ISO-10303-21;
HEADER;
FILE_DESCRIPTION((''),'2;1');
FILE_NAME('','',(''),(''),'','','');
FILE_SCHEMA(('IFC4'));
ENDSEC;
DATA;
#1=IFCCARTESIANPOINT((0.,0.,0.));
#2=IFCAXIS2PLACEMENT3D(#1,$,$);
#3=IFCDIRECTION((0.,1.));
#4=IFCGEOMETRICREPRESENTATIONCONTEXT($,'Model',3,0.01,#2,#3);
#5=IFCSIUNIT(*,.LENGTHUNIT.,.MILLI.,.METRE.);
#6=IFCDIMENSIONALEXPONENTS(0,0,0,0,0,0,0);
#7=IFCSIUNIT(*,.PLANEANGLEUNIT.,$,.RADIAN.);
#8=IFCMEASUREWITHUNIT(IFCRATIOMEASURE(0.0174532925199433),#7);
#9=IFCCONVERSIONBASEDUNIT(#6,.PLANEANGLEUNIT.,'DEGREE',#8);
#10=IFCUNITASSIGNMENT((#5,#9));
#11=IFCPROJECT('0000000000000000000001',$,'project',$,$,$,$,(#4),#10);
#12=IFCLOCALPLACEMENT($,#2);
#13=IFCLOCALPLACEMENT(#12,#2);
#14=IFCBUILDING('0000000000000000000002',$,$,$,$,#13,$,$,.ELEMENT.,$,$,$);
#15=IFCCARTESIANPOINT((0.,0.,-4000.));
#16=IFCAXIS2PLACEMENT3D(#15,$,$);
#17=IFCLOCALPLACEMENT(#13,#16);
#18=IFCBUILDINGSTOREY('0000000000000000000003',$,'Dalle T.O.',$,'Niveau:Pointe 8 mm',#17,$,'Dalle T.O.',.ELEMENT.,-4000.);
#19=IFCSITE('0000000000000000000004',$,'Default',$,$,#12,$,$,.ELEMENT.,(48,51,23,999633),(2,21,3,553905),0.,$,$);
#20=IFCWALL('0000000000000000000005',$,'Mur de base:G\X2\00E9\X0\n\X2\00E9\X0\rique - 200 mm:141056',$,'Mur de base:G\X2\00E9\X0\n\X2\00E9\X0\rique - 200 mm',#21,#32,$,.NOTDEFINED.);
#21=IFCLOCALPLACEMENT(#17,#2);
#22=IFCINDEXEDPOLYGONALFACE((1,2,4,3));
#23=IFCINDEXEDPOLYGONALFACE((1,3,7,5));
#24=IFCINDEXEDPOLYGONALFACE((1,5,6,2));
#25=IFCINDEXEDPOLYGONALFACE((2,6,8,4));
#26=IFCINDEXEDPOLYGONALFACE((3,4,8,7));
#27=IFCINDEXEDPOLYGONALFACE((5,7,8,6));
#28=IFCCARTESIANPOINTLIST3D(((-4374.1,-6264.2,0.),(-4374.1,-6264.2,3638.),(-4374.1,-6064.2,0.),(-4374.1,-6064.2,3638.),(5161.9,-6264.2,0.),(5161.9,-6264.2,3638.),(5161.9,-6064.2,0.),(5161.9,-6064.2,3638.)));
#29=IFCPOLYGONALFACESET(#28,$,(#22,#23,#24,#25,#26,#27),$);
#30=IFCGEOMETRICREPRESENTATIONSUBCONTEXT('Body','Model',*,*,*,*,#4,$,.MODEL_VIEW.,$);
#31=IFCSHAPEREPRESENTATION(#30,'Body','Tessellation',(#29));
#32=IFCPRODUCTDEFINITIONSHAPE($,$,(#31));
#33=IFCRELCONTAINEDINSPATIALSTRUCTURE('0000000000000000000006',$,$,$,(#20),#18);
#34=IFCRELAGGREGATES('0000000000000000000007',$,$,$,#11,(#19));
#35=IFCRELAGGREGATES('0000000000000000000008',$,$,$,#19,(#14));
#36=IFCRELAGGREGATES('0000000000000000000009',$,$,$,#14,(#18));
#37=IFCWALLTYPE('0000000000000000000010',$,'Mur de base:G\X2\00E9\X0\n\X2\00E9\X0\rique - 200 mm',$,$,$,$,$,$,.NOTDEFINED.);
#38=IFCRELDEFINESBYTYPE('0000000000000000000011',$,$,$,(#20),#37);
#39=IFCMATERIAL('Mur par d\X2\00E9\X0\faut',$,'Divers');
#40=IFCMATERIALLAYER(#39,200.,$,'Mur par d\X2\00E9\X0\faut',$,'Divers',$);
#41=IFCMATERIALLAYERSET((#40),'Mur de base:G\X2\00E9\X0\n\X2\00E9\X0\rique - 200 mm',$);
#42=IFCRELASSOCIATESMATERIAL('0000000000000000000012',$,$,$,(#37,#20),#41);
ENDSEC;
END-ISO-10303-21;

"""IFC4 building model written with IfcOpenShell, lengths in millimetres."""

from ifc_helpers import new_model, entity, si_unit, converted_unit, direction, frame, frame_2d, origin, place, context, subcontext, project, spatial, rectangle, extrude, material, layer, layer_set, layer_usage, type_object, element, save


model = new_model("IFC4")

# Units and contexts
model_context = context("Model", 3, precision=0.01, world=origin(), true_north=direction((0.0, 1.0)))
body_context = subcontext(model_context, "Body", "Model", "MODEL_VIEW")
ifc_project = project(units=[si_unit("LENGTHUNIT", "METRE", prefix="MILLI"), converted_unit("PLANEANGLEUNIT", "DEGREE", entity("IfcRatioMeasure", 0.0174532925199433), si_unit("PLANEANGLEUNIT", "RADIAN"), dimensions=[0, 0, 0, 0, 0, 0, 0])], contexts=[model_context])

# Site, building, storey
site_placement = place(None, origin())
site = spatial("IfcSite", under=ifc_project, at=site_placement, Name="Default", CompositionType="ELEMENT", RefLatitude=(48, 51, 23, 999633), RefLongitude=(2, 21, 3, 553905), RefElevation=0.0)
building_placement = place(site_placement, origin())
building = spatial("IfcBuilding", under=site, at=building_placement, CompositionType="ELEMENT")
storey_placement = place(building_placement, frame((0.0, 0.0, -4000.0)))
storey = spatial("IfcBuildingStorey", under=building, at=storey_placement, Name="Dalle T.O.", ObjectType="Niveau:Pointe 8 mm", LongName="Dalle T.O.", CompositionType="ELEMENT", Elevation=-4000.0)

# Wall
ifc_material_1 = material(Name="Mur par défaut", Category="Divers")
ifc_layer_1 = layer(ifc_material_1, 200.0, Name="Mur par défaut", Category="Divers")
ifc_layer_set_1 = layer_set([ifc_layer_1], Name="Mur de base:Générique - 200 mm")
wall_type_1 = type_object("IfcWallType", Name="Mur de base:Générique - 200 mm", PredefinedType="NOTDEFINED", material=ifc_layer_set_1)
ifc_layer_usage_1 = layer_usage(ifc_layer_set_1, "AXIS2", "NEGATIVE", 100.0)
wall_1_placement = place(storey_placement, frame((5161.9, -6164.2, 0.0), z_axis=(0.0, 0.0, 1.0), x_axis=(-1.0, 0.0, 0.0)))
element("IfcWall", 1, at=wall_1_placement, inside=storey, type_object=wall_type_1, material=ifc_layer_usage_1, Name="Mur de base:Générique - 200 mm:141056", ObjectType="Mur de base:Générique - 200 mm", PredefinedType="NOTDEFINED", context=body_context, shape_type="SweptSolid", body=[
    extrude(rectangle(XDim=9536.0, YDim=200.0, at=frame_2d((4768.0, 0.0), x_axis=(-1.0, 0.0))), origin(), (0.0, 0.0, 1.0), 3638.0),
])

save(model, "model.ifc")
